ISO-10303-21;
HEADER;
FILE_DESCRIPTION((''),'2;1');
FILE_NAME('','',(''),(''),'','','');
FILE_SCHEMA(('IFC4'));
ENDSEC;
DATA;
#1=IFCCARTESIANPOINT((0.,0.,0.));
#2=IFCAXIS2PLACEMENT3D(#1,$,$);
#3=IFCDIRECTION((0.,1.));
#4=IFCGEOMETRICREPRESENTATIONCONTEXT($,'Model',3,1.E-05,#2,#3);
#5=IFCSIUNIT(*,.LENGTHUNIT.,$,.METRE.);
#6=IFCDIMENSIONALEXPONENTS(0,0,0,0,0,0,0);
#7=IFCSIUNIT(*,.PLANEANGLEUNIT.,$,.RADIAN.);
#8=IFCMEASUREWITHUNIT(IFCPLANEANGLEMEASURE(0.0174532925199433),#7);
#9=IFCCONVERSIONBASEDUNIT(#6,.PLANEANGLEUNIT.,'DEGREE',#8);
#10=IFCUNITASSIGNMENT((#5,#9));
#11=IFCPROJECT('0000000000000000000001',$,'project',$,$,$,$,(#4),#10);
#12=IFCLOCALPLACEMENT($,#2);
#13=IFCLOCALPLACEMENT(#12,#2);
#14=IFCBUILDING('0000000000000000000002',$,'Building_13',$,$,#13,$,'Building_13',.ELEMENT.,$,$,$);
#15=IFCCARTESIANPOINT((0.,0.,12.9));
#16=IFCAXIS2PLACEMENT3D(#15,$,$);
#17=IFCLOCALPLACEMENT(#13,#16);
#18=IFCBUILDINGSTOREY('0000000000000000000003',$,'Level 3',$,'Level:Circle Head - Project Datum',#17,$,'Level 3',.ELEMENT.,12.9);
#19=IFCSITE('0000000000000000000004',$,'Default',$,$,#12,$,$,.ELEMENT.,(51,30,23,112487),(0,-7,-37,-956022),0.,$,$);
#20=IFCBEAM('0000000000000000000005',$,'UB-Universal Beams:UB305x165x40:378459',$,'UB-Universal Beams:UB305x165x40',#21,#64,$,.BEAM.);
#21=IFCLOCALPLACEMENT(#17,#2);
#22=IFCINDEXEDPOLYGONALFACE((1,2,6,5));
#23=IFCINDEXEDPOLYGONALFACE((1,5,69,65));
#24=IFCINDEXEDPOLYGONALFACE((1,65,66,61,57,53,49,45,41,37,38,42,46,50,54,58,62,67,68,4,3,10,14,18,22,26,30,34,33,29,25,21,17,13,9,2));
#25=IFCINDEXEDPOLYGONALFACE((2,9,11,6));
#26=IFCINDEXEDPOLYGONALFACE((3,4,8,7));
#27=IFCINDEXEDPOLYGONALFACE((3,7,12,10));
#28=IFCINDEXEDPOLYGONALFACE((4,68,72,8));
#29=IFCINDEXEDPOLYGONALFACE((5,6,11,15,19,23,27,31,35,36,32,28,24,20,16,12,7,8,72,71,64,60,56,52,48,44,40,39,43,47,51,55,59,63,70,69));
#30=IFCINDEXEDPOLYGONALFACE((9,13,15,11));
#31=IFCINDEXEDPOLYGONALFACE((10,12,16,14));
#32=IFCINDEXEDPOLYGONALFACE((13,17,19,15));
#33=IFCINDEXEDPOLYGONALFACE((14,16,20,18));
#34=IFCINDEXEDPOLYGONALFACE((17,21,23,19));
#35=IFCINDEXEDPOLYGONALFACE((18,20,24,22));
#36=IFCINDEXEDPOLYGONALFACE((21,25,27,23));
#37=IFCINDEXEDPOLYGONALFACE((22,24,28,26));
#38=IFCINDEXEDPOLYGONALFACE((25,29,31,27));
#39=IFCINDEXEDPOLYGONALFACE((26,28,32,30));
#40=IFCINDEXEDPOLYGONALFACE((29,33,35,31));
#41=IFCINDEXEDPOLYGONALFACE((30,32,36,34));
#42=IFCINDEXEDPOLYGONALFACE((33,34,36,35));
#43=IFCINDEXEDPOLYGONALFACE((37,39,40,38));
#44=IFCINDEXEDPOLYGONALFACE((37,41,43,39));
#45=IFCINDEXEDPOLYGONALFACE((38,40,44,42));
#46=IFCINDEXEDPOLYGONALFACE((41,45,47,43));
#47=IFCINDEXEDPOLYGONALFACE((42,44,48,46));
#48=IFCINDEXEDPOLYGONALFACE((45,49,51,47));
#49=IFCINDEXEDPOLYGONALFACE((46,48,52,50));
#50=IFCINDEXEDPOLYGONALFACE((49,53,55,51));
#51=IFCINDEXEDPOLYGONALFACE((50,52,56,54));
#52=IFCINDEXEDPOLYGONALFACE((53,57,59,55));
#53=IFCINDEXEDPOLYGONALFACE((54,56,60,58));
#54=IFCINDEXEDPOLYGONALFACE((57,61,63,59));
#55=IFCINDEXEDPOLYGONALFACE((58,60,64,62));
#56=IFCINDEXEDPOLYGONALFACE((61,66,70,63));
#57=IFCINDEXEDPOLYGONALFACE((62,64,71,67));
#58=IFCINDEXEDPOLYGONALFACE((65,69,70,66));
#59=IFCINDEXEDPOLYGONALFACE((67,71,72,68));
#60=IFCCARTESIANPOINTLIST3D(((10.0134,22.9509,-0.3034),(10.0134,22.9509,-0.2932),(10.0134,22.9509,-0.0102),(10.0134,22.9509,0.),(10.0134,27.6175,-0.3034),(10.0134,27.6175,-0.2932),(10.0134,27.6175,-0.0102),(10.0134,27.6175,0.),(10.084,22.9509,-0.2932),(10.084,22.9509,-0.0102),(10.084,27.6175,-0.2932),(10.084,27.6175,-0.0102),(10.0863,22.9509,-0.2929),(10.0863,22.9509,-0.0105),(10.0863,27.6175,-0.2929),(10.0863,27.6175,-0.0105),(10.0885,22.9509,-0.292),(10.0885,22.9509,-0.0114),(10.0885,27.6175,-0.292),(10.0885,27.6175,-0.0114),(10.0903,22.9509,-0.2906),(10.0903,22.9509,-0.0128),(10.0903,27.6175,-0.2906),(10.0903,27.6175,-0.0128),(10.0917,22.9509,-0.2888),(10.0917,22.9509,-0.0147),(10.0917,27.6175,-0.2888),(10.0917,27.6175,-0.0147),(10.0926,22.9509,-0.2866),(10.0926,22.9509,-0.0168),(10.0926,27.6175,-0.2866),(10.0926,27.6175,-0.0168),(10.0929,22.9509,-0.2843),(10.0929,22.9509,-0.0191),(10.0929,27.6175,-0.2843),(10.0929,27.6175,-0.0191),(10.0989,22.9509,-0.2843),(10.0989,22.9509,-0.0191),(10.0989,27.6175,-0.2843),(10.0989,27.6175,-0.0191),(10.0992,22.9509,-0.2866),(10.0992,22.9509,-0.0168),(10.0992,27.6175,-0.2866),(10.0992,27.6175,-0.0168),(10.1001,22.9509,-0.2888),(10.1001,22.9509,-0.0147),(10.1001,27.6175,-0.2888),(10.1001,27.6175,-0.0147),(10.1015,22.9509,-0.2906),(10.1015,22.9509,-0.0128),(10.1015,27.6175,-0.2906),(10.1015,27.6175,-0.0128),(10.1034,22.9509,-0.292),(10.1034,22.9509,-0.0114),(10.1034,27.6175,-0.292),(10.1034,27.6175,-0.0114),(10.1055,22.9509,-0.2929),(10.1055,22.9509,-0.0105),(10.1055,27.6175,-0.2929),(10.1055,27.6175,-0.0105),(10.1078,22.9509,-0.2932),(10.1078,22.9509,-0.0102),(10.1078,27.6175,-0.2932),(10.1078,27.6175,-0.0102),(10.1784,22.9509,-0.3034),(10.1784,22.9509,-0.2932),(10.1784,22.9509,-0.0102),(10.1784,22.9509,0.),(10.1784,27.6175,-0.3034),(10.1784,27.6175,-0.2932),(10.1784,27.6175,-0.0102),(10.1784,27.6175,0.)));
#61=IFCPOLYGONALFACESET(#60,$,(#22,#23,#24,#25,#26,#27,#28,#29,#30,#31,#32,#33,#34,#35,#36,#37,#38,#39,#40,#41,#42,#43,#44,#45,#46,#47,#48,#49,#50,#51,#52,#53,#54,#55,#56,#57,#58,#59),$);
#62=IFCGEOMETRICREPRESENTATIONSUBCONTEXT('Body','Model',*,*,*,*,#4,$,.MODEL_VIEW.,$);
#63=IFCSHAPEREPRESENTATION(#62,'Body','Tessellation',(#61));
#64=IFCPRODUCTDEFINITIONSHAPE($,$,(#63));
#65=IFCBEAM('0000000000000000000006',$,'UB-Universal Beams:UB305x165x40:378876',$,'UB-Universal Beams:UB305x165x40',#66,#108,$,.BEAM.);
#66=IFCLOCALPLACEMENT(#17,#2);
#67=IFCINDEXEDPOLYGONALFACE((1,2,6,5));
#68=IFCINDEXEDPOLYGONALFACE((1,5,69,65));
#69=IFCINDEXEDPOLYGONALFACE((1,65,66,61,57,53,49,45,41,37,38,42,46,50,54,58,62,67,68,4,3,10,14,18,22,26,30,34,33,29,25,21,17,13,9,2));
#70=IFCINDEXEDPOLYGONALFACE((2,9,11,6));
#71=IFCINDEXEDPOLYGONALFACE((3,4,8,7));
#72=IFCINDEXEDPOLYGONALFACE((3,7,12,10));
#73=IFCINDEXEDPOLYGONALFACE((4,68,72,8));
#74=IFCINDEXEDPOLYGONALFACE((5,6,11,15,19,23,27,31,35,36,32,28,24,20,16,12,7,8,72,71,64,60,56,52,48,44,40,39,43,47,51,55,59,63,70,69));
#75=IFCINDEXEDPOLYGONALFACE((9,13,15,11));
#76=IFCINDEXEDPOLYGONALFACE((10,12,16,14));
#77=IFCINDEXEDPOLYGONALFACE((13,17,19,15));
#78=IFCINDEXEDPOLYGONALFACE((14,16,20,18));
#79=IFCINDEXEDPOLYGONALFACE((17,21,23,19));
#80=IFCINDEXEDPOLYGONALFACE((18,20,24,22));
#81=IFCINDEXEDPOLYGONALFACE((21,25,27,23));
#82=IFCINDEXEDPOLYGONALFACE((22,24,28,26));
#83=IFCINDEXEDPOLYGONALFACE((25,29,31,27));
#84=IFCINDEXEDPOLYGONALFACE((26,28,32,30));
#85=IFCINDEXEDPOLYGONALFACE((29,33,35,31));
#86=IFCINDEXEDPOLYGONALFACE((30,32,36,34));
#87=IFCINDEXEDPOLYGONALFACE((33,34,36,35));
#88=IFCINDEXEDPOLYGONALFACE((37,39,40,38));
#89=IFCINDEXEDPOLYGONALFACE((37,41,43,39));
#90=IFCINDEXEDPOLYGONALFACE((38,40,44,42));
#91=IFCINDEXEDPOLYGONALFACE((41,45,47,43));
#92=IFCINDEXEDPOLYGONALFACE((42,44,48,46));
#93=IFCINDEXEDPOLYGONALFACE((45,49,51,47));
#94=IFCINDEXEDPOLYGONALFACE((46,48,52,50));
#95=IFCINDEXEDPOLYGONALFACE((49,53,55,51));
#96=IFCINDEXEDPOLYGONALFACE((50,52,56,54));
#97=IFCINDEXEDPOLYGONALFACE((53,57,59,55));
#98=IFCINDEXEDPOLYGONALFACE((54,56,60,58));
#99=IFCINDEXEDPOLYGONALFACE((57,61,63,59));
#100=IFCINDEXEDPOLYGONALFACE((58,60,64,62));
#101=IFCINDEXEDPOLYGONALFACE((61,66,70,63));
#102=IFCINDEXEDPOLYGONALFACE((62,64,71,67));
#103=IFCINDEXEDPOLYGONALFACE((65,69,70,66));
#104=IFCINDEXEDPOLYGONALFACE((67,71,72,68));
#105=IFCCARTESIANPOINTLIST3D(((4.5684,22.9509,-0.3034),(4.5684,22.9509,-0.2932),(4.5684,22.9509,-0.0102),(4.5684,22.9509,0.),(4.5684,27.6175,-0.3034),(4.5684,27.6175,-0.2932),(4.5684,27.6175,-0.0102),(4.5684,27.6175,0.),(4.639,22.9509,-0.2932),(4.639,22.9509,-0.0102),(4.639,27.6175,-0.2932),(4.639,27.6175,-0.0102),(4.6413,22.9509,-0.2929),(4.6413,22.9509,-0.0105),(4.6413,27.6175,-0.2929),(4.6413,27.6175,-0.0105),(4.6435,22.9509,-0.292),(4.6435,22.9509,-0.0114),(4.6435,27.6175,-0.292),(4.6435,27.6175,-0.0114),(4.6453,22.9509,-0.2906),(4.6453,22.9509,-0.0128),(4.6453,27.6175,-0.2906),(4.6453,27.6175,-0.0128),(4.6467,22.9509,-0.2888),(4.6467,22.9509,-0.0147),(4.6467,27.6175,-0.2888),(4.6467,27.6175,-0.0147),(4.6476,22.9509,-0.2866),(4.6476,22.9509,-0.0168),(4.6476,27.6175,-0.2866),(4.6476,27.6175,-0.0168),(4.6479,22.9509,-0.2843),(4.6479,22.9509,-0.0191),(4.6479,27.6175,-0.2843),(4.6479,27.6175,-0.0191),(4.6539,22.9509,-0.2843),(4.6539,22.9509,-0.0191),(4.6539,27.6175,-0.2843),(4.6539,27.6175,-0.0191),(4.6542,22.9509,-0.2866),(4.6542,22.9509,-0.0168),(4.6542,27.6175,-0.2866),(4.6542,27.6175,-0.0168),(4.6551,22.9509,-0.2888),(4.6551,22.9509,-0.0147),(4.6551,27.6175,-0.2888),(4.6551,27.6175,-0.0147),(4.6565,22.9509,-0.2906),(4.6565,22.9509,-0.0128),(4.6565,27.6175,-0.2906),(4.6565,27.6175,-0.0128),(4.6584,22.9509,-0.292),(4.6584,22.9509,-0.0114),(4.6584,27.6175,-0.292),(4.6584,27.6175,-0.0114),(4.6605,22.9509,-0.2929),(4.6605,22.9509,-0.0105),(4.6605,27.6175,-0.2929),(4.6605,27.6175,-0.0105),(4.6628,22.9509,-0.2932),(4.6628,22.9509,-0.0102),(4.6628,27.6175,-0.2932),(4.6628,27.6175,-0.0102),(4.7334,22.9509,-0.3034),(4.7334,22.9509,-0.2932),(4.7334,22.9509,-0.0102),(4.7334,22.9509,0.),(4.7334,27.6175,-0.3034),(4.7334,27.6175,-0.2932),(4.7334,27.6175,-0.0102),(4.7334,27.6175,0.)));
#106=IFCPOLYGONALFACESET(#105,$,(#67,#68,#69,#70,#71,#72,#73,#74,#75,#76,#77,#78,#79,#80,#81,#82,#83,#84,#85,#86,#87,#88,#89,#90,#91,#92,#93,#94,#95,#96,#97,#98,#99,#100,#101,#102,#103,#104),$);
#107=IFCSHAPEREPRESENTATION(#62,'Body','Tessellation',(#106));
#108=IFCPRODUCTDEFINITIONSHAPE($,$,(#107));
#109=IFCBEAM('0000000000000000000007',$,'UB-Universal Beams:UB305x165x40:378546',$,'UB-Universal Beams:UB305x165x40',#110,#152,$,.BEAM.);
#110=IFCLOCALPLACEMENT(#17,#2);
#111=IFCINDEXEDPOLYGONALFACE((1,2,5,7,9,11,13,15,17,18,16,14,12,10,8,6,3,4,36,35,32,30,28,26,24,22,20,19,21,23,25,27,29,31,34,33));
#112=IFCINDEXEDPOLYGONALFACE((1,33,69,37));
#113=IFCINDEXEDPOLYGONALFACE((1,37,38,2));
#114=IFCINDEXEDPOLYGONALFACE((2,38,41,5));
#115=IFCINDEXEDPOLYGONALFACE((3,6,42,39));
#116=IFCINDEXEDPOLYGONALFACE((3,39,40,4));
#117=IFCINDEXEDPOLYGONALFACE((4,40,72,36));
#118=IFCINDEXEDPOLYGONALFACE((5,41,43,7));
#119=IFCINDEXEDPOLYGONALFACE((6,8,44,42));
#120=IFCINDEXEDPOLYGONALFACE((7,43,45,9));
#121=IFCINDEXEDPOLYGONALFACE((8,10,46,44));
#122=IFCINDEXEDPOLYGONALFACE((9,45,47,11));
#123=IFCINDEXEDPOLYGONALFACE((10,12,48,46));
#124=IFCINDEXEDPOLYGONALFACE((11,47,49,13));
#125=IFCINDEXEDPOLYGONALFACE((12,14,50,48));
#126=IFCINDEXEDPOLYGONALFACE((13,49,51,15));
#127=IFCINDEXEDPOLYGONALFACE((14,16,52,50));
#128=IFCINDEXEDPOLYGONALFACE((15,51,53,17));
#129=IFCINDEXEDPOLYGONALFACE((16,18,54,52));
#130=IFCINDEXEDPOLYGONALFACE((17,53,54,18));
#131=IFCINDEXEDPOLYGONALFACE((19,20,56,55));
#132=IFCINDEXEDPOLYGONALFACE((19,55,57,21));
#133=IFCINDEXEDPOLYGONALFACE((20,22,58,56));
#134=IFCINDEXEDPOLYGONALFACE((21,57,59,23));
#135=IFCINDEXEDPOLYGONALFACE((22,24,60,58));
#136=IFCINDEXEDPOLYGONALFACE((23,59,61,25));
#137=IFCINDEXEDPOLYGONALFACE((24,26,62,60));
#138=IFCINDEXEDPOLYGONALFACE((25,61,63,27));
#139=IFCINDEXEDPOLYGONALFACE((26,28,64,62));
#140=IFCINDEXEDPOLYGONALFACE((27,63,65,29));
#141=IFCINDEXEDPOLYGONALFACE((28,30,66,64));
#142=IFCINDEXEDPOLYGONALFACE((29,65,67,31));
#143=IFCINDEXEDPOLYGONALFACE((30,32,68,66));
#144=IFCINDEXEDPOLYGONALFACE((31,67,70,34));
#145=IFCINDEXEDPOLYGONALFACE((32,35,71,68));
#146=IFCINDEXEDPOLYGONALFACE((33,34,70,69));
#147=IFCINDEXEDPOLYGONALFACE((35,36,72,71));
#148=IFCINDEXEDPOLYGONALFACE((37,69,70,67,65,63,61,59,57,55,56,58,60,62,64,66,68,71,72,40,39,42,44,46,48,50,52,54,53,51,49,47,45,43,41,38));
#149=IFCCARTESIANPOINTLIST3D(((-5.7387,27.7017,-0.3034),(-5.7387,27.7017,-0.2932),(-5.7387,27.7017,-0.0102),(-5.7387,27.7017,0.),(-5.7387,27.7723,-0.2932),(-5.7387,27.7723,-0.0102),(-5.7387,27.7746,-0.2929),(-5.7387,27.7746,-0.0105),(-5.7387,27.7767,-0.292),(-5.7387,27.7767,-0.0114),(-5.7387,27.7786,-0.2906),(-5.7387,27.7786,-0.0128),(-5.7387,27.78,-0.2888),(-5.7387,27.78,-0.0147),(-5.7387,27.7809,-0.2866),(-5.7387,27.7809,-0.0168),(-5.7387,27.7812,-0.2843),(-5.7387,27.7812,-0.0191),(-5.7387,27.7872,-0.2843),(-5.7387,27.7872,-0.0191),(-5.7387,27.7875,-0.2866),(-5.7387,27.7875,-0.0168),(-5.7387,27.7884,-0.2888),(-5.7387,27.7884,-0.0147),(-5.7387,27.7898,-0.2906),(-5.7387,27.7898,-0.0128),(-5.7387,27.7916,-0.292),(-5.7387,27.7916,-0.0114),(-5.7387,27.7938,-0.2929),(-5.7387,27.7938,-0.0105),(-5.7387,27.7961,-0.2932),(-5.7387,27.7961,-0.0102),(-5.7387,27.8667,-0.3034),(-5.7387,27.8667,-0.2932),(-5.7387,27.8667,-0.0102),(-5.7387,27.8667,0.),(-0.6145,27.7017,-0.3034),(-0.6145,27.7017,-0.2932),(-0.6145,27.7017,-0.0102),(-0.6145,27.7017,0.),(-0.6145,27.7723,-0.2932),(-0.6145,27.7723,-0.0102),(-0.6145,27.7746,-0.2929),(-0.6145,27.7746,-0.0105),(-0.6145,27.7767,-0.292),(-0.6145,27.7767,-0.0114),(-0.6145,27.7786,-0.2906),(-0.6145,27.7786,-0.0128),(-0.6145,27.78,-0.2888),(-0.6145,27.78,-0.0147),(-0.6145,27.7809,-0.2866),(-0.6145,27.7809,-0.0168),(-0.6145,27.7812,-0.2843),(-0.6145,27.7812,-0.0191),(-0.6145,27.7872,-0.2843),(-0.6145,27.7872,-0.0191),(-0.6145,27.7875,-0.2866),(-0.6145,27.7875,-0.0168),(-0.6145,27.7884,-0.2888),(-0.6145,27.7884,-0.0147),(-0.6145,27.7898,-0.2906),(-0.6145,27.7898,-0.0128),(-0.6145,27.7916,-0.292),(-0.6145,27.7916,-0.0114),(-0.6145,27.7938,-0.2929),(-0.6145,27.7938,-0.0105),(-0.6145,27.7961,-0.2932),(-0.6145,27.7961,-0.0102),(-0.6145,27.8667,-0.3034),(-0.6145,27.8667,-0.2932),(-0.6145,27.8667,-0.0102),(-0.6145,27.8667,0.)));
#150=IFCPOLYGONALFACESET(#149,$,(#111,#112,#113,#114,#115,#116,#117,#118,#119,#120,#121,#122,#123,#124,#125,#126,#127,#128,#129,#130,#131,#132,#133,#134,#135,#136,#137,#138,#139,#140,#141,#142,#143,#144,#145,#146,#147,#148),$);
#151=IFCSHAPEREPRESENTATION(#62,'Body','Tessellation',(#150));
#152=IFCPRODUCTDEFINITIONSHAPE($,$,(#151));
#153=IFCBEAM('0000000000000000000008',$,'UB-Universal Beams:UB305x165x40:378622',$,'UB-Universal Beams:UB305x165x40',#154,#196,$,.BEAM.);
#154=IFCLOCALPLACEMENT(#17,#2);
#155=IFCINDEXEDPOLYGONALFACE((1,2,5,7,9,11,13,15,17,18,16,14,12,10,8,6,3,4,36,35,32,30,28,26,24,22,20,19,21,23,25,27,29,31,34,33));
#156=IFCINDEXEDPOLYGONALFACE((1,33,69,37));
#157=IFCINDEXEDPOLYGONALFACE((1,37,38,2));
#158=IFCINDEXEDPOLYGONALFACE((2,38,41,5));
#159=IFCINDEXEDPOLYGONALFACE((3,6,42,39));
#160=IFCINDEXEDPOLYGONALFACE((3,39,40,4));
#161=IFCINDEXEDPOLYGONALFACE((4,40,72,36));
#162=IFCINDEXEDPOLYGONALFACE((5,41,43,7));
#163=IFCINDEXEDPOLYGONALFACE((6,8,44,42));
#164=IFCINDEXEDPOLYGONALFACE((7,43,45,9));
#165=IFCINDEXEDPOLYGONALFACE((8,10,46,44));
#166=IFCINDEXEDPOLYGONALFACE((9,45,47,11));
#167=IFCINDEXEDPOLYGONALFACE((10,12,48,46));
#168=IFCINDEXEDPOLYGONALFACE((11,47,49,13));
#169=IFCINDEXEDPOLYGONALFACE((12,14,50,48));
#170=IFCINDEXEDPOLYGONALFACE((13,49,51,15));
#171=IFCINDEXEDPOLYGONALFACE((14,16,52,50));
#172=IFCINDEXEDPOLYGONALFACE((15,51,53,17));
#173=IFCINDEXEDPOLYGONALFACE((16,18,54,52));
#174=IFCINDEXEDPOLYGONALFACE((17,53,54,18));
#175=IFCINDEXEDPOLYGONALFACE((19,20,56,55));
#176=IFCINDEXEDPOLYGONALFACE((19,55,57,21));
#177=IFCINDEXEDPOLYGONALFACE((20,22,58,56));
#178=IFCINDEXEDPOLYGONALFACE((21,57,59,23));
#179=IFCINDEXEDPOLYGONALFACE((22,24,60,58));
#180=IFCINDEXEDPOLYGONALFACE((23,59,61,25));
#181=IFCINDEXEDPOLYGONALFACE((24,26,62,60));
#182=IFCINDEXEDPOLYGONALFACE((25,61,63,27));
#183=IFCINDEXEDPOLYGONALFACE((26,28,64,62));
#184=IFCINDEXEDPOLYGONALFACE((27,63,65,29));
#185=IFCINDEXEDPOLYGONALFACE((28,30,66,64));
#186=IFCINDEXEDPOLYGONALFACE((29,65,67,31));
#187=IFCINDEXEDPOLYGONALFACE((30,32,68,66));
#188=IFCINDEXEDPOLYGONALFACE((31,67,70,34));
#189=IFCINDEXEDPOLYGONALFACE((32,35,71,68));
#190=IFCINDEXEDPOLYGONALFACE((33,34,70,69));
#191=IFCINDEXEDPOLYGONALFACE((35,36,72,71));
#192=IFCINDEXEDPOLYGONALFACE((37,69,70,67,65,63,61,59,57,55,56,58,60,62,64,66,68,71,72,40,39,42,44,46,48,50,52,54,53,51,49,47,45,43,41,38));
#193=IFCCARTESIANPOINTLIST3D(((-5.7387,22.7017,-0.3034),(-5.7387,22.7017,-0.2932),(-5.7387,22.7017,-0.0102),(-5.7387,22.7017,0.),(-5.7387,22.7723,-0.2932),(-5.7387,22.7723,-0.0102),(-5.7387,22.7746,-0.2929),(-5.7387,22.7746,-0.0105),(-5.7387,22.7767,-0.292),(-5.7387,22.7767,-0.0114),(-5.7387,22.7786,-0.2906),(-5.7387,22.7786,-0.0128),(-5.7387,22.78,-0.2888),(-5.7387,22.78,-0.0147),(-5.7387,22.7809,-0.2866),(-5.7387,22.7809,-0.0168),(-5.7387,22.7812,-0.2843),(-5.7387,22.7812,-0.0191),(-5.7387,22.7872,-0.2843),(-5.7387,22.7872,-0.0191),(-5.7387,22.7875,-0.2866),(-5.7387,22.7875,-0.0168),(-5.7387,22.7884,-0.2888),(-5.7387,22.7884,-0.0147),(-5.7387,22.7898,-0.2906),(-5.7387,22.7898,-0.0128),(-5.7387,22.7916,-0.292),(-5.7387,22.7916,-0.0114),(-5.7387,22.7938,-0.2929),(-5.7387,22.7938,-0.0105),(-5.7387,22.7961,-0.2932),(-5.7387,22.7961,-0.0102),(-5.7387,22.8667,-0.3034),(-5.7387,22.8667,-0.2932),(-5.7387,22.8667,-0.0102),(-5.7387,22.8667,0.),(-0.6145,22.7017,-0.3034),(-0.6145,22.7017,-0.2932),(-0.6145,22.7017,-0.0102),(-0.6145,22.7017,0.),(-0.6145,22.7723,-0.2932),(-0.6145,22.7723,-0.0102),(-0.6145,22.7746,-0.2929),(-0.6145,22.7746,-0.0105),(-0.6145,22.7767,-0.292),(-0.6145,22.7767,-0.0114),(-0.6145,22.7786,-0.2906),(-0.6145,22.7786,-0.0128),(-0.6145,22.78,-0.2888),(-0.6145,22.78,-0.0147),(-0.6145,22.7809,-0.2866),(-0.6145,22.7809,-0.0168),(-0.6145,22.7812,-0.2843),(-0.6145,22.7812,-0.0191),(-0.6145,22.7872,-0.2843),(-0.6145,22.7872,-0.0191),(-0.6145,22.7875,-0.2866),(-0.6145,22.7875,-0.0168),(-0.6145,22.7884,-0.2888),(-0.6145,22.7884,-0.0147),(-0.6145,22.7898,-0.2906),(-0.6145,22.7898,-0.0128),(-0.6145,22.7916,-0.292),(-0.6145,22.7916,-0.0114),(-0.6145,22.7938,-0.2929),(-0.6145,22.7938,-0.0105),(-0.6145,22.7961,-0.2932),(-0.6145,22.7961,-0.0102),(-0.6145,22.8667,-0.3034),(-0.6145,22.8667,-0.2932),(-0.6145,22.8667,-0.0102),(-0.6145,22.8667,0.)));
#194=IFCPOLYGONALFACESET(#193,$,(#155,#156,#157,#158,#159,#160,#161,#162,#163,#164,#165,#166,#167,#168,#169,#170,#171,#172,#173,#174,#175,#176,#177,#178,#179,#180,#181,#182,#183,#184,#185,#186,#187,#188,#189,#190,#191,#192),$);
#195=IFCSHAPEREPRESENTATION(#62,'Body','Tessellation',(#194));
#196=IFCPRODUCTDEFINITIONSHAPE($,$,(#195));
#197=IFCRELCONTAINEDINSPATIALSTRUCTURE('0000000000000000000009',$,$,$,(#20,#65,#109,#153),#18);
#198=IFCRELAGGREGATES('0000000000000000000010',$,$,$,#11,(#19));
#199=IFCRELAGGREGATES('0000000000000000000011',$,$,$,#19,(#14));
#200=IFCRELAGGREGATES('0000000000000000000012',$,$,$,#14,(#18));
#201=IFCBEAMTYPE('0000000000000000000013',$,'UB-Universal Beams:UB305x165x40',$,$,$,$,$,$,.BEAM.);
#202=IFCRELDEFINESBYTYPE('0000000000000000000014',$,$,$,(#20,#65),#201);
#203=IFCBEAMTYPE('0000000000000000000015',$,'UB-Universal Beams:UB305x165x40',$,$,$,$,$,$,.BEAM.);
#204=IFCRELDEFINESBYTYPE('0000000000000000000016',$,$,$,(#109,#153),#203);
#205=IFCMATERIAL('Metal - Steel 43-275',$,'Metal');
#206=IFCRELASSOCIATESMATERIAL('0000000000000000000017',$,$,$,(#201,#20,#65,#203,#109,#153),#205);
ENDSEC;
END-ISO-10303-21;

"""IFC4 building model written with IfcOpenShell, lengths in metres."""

from ifc_helpers import new_model, entity, si_unit, converted_unit, direction, frame, origin, place, context, subcontext, project, spatial, line, arc, indexed_curve, outline, extrude, source, transform, mapped, material, type_object, type_shapes, element, save


model = new_model("IFC4")

# Units and contexts
model_context = context("Model", 3, precision=1e-05, world=origin(), true_north=direction((0.0, 1.0)))
body_context = subcontext(model_context, "Body", "Model", "MODEL_VIEW")
ifc_project = project(units=[si_unit("LENGTHUNIT", "METRE"), converted_unit("PLANEANGLEUNIT", "DEGREE", entity("IfcPlaneAngleMeasure", 0.0174532925199433), si_unit("PLANEANGLEUNIT", "RADIAN"), dimensions=[0, 0, 0, 0, 0, 0, 0])], contexts=[model_context])

# Site, building, storey
site_placement = place(None, origin())
site = spatial("IfcSite", under=ifc_project, at=site_placement, Name="Default", CompositionType="ELEMENT", RefLatitude=(51, 30, 23, 112487), RefLongitude=(0, -7, -37, -956022), RefElevation=0.0)
building_placement = place(site_placement, origin())
building = spatial("IfcBuilding", under=site, at=building_placement, Name="Building_13", LongName="Building_13", CompositionType="ELEMENT")
storey_placement = place(building_placement, frame((0.0, 0.0, 12.9)))
storey = spatial("IfcBuildingStorey", under=building, at=storey_placement, Name="Level 3", ObjectType="Level:Circle Head - Project Datum", LongName="Level 3", CompositionType="ELEMENT", Elevation=12.9)

# Beams
ifc_material_1 = material(Name="Metal - Steel 43-275", Category="Metal")
beam_type_1 = type_object("IfcBeamType", Name="UB-Universal Beams:UB305x165x40", PredefinedType="BEAM", material=ifc_material_1)
shared_shape_1 = source(origin(), body_context, "Body", "SweptSolid", [
    extrude(outline(indexed_curve([(-0.0825, -0.1415), (-0.0825, -0.1517), (0.0825, -0.1517), (0.0825, -0.1415), (0.0119, -0.1415), (0.0056, -0.1389), (0.003, -0.1326), (0.003, 0.1326), (0.0056, 0.1389), (0.0119, 0.1415), (0.0825, 0.1415), (0.0825, 0.1517), (-0.0825, 0.1517), (-0.0825, 0.1415), (-0.0119, 0.1415), (-0.0056, 0.1389), (-0.003, 0.1326), (-0.003, -0.1326), (-0.0056, -0.1389), (-0.0119, -0.1415)], segments=[line(1, 2, 3, 4, 5), arc(5, 6, 7), line(7, 8), arc(8, 9, 10), line(10, 11, 12, 13, 14, 15), arc(15, 16, 17), line(17, 18), arc(18, 19, 20), line(20, 1)], self_intersect=False)), frame((-2.3333, 0.0, 0.0), z_axis=(-1.0, 0.0, 0.0), x_axis=(0.0, -1.0, 0.0)), (0.0, 0.0, -1.0), 4.6666),
])
type_shapes(beam_type_1, [shared_shape_1])
for number, where, z_axis, x_axis, name in (
    (1, (10.0959, 25.2842, -0.1517), (0.0, 0.0, 1.0), (0.0, -1.0, 0.0), "UB-Universal Beams:UB305x165x40:378459"),
    (2, (4.6509, 25.2842, -0.1517), (0.0, 0.0, 1.0), (0.0, -1.0, 0.0), "UB-Universal Beams:UB305x165x40:378876"),
):
    element("IfcBeam", number, at=place(storey_placement, frame(where, z_axis=z_axis, x_axis=x_axis)), inside=storey, type_object=beam_type_1, material=ifc_material_1, Name=name, ObjectType="UB-Universal Beams:UB305x165x40", PredefinedType="BEAM", context=body_context, shape_type="MappedRepresentation", body=[
        mapped(shared_shape_1, transform((0.0, 0.0, 0.0), scale=1.0)),
    ])
beam_type_2 = type_object("IfcBeamType", Name="UB-Universal Beams:UB305x165x40", PredefinedType="BEAM", material=ifc_material_1)
shared_shape_2 = source(origin(), body_context, "Body", "SweptSolid", [
    extrude(outline(indexed_curve([(-0.0825, -0.1415), (-0.0825, -0.1517), (0.0825, -0.1517), (0.0825, -0.1415), (0.0119, -0.1415), (0.0056, -0.1389), (0.003, -0.1326), (0.003, 0.1326), (0.0056, 0.1389), (0.0119, 0.1415), (0.0825, 0.1415), (0.0825, 0.1517), (-0.0825, 0.1517), (-0.0825, 0.1415), (-0.0119, 0.1415), (-0.0056, 0.1389), (-0.003, 0.1326), (-0.003, -0.1326), (-0.0056, -0.1389), (-0.0119, -0.1415)], segments=[line(1, 2, 3, 4, 5), arc(5, 6, 7), line(7, 8), arc(8, 9, 10), line(10, 11, 12, 13, 14, 15), arc(15, 16, 17), line(17, 18), arc(18, 19, 20), line(20, 1)], self_intersect=False)), frame((-2.5621, 0.0, 0.0), z_axis=(-1.0, 0.0, 0.0), x_axis=(0.0, -1.0, 0.0)), (0.0, 0.0, -1.0), 5.1242),
])
type_shapes(beam_type_2, [shared_shape_2])
for number, where, name in (
    (3, (-3.1766, 27.7842, -0.1517), "UB-Universal Beams:UB305x165x40:378546"),
    (4, (-3.1766, 22.7842, -0.1517), "UB-Universal Beams:UB305x165x40:378622"),
):
    element("IfcBeam", number, at=place(storey_placement, frame(where)), inside=storey, type_object=beam_type_2, material=ifc_material_1, Name=name, ObjectType="UB-Universal Beams:UB305x165x40", PredefinedType="BEAM", context=body_context, shape_type="MappedRepresentation", body=[
        mapped(shared_shape_2, transform((0.0, 0.0, 0.0), scale=1.0)),
    ])

save(model, "model.ifc")
